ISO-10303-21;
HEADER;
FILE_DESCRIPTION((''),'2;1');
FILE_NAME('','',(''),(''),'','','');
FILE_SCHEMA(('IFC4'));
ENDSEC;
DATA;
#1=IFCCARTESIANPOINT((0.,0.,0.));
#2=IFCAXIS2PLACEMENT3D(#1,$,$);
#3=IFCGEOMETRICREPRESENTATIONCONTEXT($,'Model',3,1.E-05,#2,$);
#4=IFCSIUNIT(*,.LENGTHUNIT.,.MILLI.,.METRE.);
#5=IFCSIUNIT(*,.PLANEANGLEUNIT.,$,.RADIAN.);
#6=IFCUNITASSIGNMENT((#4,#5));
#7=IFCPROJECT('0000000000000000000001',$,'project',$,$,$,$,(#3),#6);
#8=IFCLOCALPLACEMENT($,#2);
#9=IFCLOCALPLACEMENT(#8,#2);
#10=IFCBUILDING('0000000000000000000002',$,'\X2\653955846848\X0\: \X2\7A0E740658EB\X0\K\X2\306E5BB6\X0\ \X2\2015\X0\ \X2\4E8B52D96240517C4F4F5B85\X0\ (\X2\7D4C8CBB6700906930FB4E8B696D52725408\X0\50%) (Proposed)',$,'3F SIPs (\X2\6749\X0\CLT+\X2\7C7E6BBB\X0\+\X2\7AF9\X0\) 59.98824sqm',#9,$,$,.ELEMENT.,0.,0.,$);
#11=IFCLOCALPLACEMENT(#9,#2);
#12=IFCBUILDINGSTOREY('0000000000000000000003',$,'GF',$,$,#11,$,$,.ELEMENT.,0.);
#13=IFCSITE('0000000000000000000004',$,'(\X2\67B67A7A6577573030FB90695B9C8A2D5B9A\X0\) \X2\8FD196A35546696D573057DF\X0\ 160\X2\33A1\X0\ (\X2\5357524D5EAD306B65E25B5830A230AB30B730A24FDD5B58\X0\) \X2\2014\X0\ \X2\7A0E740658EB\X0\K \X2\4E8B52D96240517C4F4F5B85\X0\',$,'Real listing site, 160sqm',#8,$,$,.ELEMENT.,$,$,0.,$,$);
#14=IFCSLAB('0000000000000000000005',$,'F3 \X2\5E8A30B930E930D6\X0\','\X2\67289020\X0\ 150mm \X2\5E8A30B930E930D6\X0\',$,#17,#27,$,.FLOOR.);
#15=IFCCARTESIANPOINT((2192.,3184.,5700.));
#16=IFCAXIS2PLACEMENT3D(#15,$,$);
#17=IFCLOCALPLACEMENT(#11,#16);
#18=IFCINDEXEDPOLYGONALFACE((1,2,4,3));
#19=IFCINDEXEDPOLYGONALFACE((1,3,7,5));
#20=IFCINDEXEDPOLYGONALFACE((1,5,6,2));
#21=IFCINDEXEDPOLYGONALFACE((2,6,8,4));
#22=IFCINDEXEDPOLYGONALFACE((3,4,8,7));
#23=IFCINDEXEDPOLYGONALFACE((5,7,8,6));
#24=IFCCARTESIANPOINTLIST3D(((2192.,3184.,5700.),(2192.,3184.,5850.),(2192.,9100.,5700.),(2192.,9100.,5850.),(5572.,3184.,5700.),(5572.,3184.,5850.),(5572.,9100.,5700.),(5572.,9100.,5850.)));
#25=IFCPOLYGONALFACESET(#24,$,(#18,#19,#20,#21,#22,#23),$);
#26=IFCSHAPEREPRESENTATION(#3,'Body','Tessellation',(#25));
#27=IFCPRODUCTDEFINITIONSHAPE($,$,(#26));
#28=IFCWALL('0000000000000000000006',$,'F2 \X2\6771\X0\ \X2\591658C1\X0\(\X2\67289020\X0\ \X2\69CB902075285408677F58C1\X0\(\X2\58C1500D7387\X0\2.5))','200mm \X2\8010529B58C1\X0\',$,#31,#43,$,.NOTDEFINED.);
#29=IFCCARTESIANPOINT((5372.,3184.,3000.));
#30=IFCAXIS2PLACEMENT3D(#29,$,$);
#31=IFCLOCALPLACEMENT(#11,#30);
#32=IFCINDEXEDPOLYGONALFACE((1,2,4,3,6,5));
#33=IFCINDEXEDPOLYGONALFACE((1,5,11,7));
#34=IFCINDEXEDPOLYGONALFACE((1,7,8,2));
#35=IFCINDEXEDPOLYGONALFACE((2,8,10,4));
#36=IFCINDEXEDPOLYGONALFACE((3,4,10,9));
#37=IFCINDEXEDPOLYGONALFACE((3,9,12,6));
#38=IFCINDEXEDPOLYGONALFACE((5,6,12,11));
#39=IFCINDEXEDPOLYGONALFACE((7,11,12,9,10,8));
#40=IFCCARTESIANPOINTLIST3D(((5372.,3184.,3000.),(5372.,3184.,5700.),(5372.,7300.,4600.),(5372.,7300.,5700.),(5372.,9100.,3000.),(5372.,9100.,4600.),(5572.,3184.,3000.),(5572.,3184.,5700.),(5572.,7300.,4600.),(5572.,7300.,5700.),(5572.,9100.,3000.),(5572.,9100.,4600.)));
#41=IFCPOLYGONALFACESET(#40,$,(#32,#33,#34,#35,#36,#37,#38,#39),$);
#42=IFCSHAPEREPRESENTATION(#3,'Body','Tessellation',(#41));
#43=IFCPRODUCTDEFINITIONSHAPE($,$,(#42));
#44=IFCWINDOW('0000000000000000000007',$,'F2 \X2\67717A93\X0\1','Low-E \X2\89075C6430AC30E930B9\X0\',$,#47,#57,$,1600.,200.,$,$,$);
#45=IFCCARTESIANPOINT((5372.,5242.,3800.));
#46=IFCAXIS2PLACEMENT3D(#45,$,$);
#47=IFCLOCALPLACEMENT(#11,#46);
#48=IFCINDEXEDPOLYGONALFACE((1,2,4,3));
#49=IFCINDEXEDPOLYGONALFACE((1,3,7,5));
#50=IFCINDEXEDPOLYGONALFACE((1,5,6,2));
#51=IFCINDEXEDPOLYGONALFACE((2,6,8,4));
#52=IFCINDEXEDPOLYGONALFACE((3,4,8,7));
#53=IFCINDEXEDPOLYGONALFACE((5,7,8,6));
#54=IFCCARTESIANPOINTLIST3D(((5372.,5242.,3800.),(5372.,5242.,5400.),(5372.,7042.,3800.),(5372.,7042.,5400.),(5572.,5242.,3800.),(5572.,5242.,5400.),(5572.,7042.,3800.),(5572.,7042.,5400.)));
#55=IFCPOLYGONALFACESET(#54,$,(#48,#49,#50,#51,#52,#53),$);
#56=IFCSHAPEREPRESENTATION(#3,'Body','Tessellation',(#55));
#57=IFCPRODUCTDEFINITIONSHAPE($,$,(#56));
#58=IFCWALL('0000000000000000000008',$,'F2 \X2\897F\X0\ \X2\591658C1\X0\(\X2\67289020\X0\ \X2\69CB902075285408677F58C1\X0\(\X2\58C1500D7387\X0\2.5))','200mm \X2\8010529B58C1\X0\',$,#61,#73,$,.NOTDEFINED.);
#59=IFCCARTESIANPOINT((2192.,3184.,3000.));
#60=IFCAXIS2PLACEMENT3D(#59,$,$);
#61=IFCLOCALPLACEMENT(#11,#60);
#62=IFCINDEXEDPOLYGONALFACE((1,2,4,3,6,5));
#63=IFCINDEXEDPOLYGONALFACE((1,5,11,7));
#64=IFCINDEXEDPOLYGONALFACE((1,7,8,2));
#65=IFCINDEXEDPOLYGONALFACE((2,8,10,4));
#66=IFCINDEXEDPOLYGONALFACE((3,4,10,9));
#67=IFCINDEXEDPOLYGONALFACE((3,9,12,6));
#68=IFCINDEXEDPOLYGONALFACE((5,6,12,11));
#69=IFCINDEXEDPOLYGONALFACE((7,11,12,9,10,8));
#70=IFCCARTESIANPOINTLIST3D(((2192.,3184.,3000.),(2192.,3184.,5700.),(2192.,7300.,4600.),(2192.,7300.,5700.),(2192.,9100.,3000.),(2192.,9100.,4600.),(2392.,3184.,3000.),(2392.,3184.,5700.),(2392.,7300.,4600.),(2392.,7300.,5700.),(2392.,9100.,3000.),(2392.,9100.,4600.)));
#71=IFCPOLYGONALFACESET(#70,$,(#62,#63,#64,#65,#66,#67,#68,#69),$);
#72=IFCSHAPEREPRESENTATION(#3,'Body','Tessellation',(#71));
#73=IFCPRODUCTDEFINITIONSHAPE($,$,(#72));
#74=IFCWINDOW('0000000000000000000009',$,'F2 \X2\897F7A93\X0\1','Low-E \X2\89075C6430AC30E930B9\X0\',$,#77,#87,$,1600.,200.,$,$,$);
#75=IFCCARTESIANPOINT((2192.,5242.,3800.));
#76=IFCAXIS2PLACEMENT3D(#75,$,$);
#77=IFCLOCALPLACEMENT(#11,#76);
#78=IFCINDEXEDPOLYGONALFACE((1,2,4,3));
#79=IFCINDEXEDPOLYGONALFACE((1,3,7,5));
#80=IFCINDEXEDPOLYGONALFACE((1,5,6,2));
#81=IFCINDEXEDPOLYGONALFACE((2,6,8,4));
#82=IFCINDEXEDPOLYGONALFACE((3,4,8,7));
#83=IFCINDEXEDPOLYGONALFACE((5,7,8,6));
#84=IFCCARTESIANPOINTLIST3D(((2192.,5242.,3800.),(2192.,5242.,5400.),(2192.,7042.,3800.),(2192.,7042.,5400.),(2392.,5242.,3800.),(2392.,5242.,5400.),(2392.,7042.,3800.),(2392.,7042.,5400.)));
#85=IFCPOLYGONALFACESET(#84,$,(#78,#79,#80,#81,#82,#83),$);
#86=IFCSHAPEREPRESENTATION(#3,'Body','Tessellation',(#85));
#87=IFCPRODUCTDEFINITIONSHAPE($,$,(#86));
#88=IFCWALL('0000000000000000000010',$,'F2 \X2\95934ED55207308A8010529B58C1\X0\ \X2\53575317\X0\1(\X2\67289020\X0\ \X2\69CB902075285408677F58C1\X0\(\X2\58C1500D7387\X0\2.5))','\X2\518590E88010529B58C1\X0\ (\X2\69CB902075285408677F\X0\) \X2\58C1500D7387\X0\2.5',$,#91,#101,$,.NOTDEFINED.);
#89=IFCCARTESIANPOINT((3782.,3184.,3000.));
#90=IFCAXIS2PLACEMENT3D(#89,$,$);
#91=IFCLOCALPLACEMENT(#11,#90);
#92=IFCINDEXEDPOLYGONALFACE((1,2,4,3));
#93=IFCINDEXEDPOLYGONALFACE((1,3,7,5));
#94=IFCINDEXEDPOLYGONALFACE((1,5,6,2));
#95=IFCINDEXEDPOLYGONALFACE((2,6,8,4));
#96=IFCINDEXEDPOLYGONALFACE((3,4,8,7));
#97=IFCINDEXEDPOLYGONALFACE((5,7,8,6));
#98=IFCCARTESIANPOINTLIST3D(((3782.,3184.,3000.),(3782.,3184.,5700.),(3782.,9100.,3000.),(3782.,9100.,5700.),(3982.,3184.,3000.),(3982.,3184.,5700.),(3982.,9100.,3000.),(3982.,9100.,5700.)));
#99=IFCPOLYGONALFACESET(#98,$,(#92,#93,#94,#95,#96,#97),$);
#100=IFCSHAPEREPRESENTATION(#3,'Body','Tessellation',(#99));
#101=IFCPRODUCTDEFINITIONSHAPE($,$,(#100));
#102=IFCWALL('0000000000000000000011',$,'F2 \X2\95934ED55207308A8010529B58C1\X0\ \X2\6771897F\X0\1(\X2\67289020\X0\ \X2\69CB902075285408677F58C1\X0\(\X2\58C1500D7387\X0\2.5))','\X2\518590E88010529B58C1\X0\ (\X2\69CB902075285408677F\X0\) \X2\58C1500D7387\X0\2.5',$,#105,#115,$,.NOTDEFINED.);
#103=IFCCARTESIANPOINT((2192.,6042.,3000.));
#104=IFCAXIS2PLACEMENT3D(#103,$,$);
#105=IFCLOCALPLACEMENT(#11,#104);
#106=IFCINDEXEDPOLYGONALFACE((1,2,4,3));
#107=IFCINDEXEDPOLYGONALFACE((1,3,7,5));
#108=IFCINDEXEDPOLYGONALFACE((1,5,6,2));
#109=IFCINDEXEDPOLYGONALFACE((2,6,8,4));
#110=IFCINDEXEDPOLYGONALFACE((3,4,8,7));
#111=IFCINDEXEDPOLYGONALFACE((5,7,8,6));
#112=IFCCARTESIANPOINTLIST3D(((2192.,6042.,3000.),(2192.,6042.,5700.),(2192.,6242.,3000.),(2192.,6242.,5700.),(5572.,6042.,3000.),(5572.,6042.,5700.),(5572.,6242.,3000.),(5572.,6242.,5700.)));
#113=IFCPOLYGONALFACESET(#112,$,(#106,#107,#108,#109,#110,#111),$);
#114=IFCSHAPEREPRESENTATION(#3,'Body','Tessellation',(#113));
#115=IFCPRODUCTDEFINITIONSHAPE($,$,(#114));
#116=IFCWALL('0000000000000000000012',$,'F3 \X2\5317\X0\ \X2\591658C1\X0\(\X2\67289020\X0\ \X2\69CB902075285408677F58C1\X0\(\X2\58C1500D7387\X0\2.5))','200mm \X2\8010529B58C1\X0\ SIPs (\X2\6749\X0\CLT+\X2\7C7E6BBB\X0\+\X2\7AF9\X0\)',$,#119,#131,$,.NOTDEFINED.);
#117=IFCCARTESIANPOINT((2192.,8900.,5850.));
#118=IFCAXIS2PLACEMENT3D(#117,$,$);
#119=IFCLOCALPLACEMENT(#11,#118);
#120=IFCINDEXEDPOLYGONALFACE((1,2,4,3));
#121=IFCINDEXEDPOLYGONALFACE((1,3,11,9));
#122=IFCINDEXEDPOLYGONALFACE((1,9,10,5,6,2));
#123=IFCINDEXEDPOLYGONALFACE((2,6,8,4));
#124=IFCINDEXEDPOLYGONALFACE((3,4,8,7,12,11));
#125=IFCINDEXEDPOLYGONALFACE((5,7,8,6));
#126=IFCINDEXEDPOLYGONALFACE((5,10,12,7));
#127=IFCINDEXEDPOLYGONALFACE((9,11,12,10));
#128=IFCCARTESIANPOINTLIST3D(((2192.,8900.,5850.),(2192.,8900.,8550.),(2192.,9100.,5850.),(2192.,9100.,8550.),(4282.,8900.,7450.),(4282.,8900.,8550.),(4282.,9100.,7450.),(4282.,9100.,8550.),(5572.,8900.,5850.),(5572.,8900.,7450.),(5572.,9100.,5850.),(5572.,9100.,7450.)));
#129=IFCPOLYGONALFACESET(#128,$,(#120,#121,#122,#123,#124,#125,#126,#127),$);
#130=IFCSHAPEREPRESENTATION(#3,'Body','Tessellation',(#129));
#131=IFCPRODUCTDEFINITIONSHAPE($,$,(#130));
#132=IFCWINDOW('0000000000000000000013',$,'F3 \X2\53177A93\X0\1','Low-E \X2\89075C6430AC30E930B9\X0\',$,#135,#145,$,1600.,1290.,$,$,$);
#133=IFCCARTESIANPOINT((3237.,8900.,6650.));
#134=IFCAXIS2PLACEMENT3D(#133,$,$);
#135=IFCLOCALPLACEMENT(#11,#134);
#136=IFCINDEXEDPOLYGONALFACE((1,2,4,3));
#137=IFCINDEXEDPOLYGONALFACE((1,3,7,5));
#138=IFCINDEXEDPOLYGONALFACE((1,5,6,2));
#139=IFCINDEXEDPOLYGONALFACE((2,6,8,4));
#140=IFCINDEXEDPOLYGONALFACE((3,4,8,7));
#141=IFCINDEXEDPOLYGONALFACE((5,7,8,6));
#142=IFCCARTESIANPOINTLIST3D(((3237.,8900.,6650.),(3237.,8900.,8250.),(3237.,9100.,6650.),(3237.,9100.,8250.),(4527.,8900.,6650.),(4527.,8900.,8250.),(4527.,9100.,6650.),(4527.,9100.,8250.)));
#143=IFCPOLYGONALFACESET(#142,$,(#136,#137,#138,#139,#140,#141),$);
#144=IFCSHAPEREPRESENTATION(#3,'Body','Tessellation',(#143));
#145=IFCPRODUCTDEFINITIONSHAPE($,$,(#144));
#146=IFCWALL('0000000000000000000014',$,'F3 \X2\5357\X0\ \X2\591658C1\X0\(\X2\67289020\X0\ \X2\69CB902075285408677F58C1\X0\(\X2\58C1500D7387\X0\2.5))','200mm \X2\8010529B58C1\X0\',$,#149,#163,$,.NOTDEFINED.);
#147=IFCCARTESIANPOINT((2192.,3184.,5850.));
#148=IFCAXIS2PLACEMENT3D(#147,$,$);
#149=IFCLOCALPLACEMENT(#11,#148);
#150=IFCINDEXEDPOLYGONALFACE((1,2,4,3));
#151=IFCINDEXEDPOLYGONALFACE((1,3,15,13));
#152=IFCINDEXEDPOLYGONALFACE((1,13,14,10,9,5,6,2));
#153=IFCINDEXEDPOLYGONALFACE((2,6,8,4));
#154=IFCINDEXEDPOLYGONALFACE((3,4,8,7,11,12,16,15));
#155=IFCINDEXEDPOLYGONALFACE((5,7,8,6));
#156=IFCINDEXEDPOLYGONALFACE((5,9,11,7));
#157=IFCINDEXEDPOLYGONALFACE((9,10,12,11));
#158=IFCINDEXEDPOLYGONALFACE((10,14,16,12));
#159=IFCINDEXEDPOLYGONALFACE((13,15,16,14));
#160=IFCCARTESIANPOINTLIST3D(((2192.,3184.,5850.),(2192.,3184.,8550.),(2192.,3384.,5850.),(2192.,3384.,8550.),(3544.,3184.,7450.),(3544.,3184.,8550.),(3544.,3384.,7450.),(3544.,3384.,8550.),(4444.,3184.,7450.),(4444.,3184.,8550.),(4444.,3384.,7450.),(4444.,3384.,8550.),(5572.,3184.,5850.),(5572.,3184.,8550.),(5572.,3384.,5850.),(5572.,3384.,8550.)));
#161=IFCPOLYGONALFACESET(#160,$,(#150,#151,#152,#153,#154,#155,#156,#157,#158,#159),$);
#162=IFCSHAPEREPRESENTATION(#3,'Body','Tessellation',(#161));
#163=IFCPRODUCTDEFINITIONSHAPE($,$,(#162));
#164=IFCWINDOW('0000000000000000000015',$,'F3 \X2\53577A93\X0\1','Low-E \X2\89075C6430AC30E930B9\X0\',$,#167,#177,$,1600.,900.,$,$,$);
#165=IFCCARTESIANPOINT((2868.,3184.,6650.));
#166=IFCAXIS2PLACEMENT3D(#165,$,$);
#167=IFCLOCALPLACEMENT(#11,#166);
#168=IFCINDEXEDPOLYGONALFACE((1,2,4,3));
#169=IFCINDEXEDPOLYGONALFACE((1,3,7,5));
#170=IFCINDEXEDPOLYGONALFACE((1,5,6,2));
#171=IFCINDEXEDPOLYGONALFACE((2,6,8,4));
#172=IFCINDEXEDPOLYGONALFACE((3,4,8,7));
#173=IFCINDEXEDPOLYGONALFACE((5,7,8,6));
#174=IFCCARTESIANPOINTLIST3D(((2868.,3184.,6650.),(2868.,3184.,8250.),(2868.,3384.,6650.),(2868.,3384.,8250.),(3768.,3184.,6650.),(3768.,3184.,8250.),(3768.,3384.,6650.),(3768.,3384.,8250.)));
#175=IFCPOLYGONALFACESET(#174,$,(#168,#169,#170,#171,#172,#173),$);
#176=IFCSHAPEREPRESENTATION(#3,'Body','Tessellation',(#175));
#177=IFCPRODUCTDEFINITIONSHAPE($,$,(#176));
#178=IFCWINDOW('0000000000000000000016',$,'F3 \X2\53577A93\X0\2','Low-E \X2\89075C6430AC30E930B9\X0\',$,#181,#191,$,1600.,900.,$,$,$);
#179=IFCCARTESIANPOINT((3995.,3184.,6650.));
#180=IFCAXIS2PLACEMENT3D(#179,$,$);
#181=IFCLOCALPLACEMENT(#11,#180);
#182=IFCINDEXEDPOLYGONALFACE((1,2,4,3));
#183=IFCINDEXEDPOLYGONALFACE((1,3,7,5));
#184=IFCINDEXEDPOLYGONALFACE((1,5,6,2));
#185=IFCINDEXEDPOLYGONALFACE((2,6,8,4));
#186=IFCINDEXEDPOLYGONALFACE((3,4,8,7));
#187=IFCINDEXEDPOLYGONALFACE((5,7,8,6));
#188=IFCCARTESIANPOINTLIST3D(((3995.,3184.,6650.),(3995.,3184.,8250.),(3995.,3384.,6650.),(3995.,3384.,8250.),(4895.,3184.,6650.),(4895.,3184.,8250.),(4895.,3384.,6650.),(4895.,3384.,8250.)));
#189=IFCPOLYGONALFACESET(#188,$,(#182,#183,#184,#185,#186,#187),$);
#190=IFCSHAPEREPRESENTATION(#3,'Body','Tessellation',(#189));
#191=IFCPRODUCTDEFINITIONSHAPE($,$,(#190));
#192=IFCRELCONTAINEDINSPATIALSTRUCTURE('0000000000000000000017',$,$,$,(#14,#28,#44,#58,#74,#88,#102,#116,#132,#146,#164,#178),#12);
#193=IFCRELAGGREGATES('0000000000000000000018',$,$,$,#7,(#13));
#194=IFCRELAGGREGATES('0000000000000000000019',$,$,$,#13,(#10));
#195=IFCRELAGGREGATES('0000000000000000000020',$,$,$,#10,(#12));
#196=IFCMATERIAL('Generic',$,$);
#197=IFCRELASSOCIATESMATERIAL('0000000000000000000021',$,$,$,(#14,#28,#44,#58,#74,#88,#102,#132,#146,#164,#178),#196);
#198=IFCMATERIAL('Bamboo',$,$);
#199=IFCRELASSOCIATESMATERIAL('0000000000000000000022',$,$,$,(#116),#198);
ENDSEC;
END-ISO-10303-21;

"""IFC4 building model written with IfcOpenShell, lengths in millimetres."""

from ifc_helpers import new_model, si_unit, frame, frame_2d, origin, place, context, project, spatial, rectangle, extrude, material, element, fill, save


model = new_model("IFC4")

# Units and contexts
model_context = context("Model", 3, precision=1e-05, world=origin())
ifc_project = project(units=[si_unit("LENGTHUNIT", "METRE", prefix="MILLI"), si_unit("PLANEANGLEUNIT", "RADIAN")], contexts=[model_context])

# Site, building, storey
site_placement = place(None, origin())
site = spatial("IfcSite", under=ifc_project, at=site_placement, Name="(架空敷地・適宜設定) 近隣商業地域 160㎡ (南前庭に既存アカシア保存) — 税理士K 事務所兼住宅", ObjectType="Real listing site, 160sqm", CompositionType="ELEMENT", RefElevation=0.0)
building_placement = place(site_placement, origin())
building = spatial("IfcBuilding", under=site, at=building_placement, Name="改善案: 税理士Kの家 ― 事務所兼住宅 (経費最適・事業割合50%) (Proposed)", ObjectType="3F SIPs (杉CLT+籾殻+竹) 59.98824sqm", CompositionType="ELEMENT", ElevationOfRefHeight=0.0, ElevationOfTerrain=0.0)
storey_placement = place(building_placement, origin())
storey = spatial("IfcBuildingStorey", under=building, at=storey_placement, Name="GF", CompositionType="ELEMENT", Elevation=0.0)

# Slab
ifc_material_1 = material(Name="Generic")
slab_placement = place(storey_placement, frame((2192.0, 3184.0, 5700.0)))
element("IfcSlab", 1, at=slab_placement, inside=storey, material=ifc_material_1, Name="F3 床スラブ", Description="木造 150mm 床スラブ", PredefinedType="FLOOR", context=model_context, shape_type="SweptSolid", body=[
    extrude(rectangle(XDim=3380.0, YDim=5916.0, at=frame_2d((1690.0, 2958.0))), frame((2192.0, 3184.0, 5700.0)), (0.0, 0.0, 1.0), 150.0),
])

# Walls, openings, windows
wall_1_placement = place(storey_placement, frame((5372.0, 3184.0, 3000.0)))
wall_1 = element("IfcWall", 2, at=wall_1_placement, inside=storey, material=ifc_material_1, Name="F2 東 外壁(木造 構造用合板壁(壁倍率2.5))", Description="200mm 耐力壁", PredefinedType="NOTDEFINED", context=model_context, shape_type="SweptSolid", body=[
    extrude(rectangle(XDim=200.0, YDim=5916.0, at=frame_2d((100.0, 2958.0))), frame((5372.0, 3184.0, 3000.0)), (0.0, 0.0, 1.0), 2700.0),
])
opening_1_placement = place(storey_placement, frame((5372.0, 5242.0, 3800.0)))
opening_1 = element("IfcOpeningElement", 3, at=opening_1_placement, cuts=wall_1, PredefinedType="NOTDEFINED", context=model_context, shape_type="SweptSolid", body=[
    extrude(rectangle(XDim=200.0, YDim=1800.0, at=frame_2d((100.0, 900.0))), frame((5372.0, 5242.0, 3800.0)), (0.0, 0.0, 1.0), 1600.0),
])
window_1_placement = place(storey_placement, frame((5372.0, 5242.0, 3800.0)))
window_1 = element("IfcWindow", 4, at=window_1_placement, inside=storey, material=ifc_material_1, Name="F2 東窓1", Description="Low-E 複層ガラス", OverallHeight=1600.0, OverallWidth=200.0, context=model_context, shape_type="SweptSolid", body=[
    extrude(rectangle(XDim=200.0, YDim=1800.0, at=frame_2d((100.0, 900.0))), frame((5372.0, 5242.0, 3800.0)), (0.0, 0.0, 1.0), 1600.0),
])
fill(opening_1, window_1)
wall_2_placement = place(storey_placement, frame((2192.0, 3184.0, 3000.0)))
wall_2 = element("IfcWall", 5, at=wall_2_placement, inside=storey, material=ifc_material_1, Name="F2 西 外壁(木造 構造用合板壁(壁倍率2.5))", Description="200mm 耐力壁", PredefinedType="NOTDEFINED", context=model_context, shape_type="SweptSolid", body=[
    extrude(rectangle(XDim=200.0, YDim=5916.0, at=frame_2d((100.0, 2958.0))), frame((2192.0, 3184.0, 3000.0)), (0.0, 0.0, 1.0), 2700.0),
])
opening_2_placement = place(storey_placement, frame((2192.0, 5242.0, 3800.0)))
opening_2 = element("IfcOpeningElement", 6, at=opening_2_placement, cuts=wall_2, PredefinedType="NOTDEFINED", context=model_context, shape_type="SweptSolid", body=[
    extrude(rectangle(XDim=200.0, YDim=1800.0, at=frame_2d((100.0, 900.0))), frame((2192.0, 5242.0, 3800.0)), (0.0, 0.0, 1.0), 1600.0),
])
window_2_placement = place(storey_placement, frame((2192.0, 5242.0, 3800.0)))
window_2 = element("IfcWindow", 7, at=window_2_placement, inside=storey, material=ifc_material_1, Name="F2 西窓1", Description="Low-E 複層ガラス", OverallHeight=1600.0, OverallWidth=200.0, context=model_context, shape_type="SweptSolid", body=[
    extrude(rectangle(XDim=200.0, YDim=1800.0, at=frame_2d((100.0, 900.0))), frame((2192.0, 5242.0, 3800.0)), (0.0, 0.0, 1.0), 1600.0),
])
fill(opening_2, window_2)

# Walls
wall_3_placement = place(storey_placement, frame((3782.0, 3184.0, 3000.0)))
element("IfcWall", 8, at=wall_3_placement, inside=storey, material=ifc_material_1, Name="F2 間仕切り耐力壁 南北1(木造 構造用合板壁(壁倍率2.5))", Description="内部耐力壁 (構造用合板) 壁倍率2.5", PredefinedType="NOTDEFINED", context=model_context, shape_type="SweptSolid", body=[
    extrude(rectangle(XDim=200.0, YDim=5916.0, at=frame_2d((100.0, 2958.0))), frame((3782.0, 3184.0, 3000.0)), (0.0, 0.0, 1.0), 2700.0),
])
wall_4_placement = place(storey_placement, frame((2192.0, 6042.0, 3000.0)))
element("IfcWall", 9, at=wall_4_placement, inside=storey, material=ifc_material_1, Name="F2 間仕切り耐力壁 東西1(木造 構造用合板壁(壁倍率2.5))", Description="内部耐力壁 (構造用合板) 壁倍率2.5", PredefinedType="NOTDEFINED", context=model_context, shape_type="SweptSolid", body=[
    extrude(rectangle(XDim=3380.0, YDim=200.0, at=frame_2d((1690.0, 100.0))), frame((2192.0, 6042.0, 3000.0)), (0.0, 0.0, 1.0), 2700.0),
])

# Wall, opening, window
ifc_material_2 = material(Name="Bamboo")
wall_5_placement = place(storey_placement, frame((2192.0, 8900.0, 5850.0)))
wall_5 = element("IfcWall", 10, at=wall_5_placement, inside=storey, material=ifc_material_2, Name="F3 北 外壁(木造 構造用合板壁(壁倍率2.5))", Description="200mm 耐力壁 SIPs (杉CLT+籾殻+竹)", PredefinedType="NOTDEFINED", context=model_context, shape_type="SweptSolid", body=[
    extrude(rectangle(XDim=3380.0, YDim=200.0, at=frame_2d((1690.0, 100.0))), frame((2192.0, 8900.0, 5850.0)), (0.0, 0.0, 1.0), 2700.0),
])
opening_3_placement = place(storey_placement, frame((3237.0, 8900.0, 6650.0)))
opening_3 = element("IfcOpeningElement", 11, at=opening_3_placement, cuts=wall_5, PredefinedType="NOTDEFINED", context=model_context, shape_type="SweptSolid", body=[
    extrude(rectangle(XDim=1290.0, YDim=200.0, at=frame_2d((645.0, 100.0))), frame((3237.0, 8900.0, 6650.0)), (0.0, 0.0, 1.0), 1600.0),
])
window_3_placement = place(storey_placement, frame((3237.0, 8900.0, 6650.0)))
window_3 = element("IfcWindow", 12, at=window_3_placement, inside=storey, material=ifc_material_1, Name="F3 北窓1", Description="Low-E 複層ガラス", OverallHeight=1600.0, OverallWidth=1290.0, context=model_context, shape_type="SweptSolid", body=[
    extrude(rectangle(XDim=1290.0, YDim=200.0, at=frame_2d((645.0, 100.0))), frame((3237.0, 8900.0, 6650.0)), (0.0, 0.0, 1.0), 1600.0),
])
fill(opening_3, window_3)

# Wall, openings, windows
wall_6_placement = place(storey_placement, frame((2192.0, 3184.0, 5850.0)))
wall_6 = element("IfcWall", 13, at=wall_6_placement, inside=storey, material=ifc_material_1, Name="F3 南 外壁(木造 構造用合板壁(壁倍率2.5))", Description="200mm 耐力壁", PredefinedType="NOTDEFINED", context=model_context, shape_type="SweptSolid", body=[
    extrude(rectangle(XDim=3380.0, YDim=200.0, at=frame_2d((1690.0, 100.0))), frame((2192.0, 3184.0, 5850.0)), (0.0, 0.0, 1.0), 2700.0),
])
opening_4_placement = place(storey_placement, frame((2868.0, 3184.0, 6650.0)))
opening_4 = element("IfcOpeningElement", 14, at=opening_4_placement, cuts=wall_6, PredefinedType="NOTDEFINED", context=model_context, shape_type="SweptSolid", body=[
    extrude(rectangle(XDim=900.0, YDim=200.0, at=frame_2d((450.0, 100.0))), frame((2868.0, 3184.0, 6650.0)), (0.0, 0.0, 1.0), 1600.0),
])
opening_5_placement = place(storey_placement, frame((3995.0, 3184.0, 6650.0)))
opening_5 = element("IfcOpeningElement", 15, at=opening_5_placement, cuts=wall_6, PredefinedType="NOTDEFINED", context=model_context, shape_type="SweptSolid", body=[
    extrude(rectangle(XDim=900.0, YDim=200.0, at=frame_2d((450.0, 100.0))), frame((3995.0, 3184.0, 6650.0)), (0.0, 0.0, 1.0), 1600.0),
])
window_4_placement = place(storey_placement, frame((2868.0, 3184.0, 6650.0)))
window_4 = element("IfcWindow", 16, at=window_4_placement, inside=storey, material=ifc_material_1, Name="F3 南窓1", Description="Low-E 複層ガラス", OverallHeight=1600.0, OverallWidth=900.0, context=model_context, shape_type="SweptSolid", body=[
    extrude(rectangle(XDim=900.0, YDim=200.0, at=frame_2d((450.0, 100.0))), frame((2868.0, 3184.0, 6650.0)), (0.0, 0.0, 1.0), 1600.0),
])
fill(opening_4, window_4)
window_5_placement = place(storey_placement, frame((3995.0, 3184.0, 6650.0)))
window_5 = element("IfcWindow", 17, at=window_5_placement, inside=storey, material=ifc_material_1, Name="F3 南窓2", Description="Low-E 複層ガラス", OverallHeight=1600.0, OverallWidth=900.0, context=model_context, shape_type="SweptSolid", body=[
    extrude(rectangle(XDim=900.0, YDim=200.0, at=frame_2d((450.0, 100.0))), frame((3995.0, 3184.0, 6650.0)), (0.0, 0.0, 1.0), 1600.0),
])
fill(opening_5, window_5)

save(model, "model.ifc")
